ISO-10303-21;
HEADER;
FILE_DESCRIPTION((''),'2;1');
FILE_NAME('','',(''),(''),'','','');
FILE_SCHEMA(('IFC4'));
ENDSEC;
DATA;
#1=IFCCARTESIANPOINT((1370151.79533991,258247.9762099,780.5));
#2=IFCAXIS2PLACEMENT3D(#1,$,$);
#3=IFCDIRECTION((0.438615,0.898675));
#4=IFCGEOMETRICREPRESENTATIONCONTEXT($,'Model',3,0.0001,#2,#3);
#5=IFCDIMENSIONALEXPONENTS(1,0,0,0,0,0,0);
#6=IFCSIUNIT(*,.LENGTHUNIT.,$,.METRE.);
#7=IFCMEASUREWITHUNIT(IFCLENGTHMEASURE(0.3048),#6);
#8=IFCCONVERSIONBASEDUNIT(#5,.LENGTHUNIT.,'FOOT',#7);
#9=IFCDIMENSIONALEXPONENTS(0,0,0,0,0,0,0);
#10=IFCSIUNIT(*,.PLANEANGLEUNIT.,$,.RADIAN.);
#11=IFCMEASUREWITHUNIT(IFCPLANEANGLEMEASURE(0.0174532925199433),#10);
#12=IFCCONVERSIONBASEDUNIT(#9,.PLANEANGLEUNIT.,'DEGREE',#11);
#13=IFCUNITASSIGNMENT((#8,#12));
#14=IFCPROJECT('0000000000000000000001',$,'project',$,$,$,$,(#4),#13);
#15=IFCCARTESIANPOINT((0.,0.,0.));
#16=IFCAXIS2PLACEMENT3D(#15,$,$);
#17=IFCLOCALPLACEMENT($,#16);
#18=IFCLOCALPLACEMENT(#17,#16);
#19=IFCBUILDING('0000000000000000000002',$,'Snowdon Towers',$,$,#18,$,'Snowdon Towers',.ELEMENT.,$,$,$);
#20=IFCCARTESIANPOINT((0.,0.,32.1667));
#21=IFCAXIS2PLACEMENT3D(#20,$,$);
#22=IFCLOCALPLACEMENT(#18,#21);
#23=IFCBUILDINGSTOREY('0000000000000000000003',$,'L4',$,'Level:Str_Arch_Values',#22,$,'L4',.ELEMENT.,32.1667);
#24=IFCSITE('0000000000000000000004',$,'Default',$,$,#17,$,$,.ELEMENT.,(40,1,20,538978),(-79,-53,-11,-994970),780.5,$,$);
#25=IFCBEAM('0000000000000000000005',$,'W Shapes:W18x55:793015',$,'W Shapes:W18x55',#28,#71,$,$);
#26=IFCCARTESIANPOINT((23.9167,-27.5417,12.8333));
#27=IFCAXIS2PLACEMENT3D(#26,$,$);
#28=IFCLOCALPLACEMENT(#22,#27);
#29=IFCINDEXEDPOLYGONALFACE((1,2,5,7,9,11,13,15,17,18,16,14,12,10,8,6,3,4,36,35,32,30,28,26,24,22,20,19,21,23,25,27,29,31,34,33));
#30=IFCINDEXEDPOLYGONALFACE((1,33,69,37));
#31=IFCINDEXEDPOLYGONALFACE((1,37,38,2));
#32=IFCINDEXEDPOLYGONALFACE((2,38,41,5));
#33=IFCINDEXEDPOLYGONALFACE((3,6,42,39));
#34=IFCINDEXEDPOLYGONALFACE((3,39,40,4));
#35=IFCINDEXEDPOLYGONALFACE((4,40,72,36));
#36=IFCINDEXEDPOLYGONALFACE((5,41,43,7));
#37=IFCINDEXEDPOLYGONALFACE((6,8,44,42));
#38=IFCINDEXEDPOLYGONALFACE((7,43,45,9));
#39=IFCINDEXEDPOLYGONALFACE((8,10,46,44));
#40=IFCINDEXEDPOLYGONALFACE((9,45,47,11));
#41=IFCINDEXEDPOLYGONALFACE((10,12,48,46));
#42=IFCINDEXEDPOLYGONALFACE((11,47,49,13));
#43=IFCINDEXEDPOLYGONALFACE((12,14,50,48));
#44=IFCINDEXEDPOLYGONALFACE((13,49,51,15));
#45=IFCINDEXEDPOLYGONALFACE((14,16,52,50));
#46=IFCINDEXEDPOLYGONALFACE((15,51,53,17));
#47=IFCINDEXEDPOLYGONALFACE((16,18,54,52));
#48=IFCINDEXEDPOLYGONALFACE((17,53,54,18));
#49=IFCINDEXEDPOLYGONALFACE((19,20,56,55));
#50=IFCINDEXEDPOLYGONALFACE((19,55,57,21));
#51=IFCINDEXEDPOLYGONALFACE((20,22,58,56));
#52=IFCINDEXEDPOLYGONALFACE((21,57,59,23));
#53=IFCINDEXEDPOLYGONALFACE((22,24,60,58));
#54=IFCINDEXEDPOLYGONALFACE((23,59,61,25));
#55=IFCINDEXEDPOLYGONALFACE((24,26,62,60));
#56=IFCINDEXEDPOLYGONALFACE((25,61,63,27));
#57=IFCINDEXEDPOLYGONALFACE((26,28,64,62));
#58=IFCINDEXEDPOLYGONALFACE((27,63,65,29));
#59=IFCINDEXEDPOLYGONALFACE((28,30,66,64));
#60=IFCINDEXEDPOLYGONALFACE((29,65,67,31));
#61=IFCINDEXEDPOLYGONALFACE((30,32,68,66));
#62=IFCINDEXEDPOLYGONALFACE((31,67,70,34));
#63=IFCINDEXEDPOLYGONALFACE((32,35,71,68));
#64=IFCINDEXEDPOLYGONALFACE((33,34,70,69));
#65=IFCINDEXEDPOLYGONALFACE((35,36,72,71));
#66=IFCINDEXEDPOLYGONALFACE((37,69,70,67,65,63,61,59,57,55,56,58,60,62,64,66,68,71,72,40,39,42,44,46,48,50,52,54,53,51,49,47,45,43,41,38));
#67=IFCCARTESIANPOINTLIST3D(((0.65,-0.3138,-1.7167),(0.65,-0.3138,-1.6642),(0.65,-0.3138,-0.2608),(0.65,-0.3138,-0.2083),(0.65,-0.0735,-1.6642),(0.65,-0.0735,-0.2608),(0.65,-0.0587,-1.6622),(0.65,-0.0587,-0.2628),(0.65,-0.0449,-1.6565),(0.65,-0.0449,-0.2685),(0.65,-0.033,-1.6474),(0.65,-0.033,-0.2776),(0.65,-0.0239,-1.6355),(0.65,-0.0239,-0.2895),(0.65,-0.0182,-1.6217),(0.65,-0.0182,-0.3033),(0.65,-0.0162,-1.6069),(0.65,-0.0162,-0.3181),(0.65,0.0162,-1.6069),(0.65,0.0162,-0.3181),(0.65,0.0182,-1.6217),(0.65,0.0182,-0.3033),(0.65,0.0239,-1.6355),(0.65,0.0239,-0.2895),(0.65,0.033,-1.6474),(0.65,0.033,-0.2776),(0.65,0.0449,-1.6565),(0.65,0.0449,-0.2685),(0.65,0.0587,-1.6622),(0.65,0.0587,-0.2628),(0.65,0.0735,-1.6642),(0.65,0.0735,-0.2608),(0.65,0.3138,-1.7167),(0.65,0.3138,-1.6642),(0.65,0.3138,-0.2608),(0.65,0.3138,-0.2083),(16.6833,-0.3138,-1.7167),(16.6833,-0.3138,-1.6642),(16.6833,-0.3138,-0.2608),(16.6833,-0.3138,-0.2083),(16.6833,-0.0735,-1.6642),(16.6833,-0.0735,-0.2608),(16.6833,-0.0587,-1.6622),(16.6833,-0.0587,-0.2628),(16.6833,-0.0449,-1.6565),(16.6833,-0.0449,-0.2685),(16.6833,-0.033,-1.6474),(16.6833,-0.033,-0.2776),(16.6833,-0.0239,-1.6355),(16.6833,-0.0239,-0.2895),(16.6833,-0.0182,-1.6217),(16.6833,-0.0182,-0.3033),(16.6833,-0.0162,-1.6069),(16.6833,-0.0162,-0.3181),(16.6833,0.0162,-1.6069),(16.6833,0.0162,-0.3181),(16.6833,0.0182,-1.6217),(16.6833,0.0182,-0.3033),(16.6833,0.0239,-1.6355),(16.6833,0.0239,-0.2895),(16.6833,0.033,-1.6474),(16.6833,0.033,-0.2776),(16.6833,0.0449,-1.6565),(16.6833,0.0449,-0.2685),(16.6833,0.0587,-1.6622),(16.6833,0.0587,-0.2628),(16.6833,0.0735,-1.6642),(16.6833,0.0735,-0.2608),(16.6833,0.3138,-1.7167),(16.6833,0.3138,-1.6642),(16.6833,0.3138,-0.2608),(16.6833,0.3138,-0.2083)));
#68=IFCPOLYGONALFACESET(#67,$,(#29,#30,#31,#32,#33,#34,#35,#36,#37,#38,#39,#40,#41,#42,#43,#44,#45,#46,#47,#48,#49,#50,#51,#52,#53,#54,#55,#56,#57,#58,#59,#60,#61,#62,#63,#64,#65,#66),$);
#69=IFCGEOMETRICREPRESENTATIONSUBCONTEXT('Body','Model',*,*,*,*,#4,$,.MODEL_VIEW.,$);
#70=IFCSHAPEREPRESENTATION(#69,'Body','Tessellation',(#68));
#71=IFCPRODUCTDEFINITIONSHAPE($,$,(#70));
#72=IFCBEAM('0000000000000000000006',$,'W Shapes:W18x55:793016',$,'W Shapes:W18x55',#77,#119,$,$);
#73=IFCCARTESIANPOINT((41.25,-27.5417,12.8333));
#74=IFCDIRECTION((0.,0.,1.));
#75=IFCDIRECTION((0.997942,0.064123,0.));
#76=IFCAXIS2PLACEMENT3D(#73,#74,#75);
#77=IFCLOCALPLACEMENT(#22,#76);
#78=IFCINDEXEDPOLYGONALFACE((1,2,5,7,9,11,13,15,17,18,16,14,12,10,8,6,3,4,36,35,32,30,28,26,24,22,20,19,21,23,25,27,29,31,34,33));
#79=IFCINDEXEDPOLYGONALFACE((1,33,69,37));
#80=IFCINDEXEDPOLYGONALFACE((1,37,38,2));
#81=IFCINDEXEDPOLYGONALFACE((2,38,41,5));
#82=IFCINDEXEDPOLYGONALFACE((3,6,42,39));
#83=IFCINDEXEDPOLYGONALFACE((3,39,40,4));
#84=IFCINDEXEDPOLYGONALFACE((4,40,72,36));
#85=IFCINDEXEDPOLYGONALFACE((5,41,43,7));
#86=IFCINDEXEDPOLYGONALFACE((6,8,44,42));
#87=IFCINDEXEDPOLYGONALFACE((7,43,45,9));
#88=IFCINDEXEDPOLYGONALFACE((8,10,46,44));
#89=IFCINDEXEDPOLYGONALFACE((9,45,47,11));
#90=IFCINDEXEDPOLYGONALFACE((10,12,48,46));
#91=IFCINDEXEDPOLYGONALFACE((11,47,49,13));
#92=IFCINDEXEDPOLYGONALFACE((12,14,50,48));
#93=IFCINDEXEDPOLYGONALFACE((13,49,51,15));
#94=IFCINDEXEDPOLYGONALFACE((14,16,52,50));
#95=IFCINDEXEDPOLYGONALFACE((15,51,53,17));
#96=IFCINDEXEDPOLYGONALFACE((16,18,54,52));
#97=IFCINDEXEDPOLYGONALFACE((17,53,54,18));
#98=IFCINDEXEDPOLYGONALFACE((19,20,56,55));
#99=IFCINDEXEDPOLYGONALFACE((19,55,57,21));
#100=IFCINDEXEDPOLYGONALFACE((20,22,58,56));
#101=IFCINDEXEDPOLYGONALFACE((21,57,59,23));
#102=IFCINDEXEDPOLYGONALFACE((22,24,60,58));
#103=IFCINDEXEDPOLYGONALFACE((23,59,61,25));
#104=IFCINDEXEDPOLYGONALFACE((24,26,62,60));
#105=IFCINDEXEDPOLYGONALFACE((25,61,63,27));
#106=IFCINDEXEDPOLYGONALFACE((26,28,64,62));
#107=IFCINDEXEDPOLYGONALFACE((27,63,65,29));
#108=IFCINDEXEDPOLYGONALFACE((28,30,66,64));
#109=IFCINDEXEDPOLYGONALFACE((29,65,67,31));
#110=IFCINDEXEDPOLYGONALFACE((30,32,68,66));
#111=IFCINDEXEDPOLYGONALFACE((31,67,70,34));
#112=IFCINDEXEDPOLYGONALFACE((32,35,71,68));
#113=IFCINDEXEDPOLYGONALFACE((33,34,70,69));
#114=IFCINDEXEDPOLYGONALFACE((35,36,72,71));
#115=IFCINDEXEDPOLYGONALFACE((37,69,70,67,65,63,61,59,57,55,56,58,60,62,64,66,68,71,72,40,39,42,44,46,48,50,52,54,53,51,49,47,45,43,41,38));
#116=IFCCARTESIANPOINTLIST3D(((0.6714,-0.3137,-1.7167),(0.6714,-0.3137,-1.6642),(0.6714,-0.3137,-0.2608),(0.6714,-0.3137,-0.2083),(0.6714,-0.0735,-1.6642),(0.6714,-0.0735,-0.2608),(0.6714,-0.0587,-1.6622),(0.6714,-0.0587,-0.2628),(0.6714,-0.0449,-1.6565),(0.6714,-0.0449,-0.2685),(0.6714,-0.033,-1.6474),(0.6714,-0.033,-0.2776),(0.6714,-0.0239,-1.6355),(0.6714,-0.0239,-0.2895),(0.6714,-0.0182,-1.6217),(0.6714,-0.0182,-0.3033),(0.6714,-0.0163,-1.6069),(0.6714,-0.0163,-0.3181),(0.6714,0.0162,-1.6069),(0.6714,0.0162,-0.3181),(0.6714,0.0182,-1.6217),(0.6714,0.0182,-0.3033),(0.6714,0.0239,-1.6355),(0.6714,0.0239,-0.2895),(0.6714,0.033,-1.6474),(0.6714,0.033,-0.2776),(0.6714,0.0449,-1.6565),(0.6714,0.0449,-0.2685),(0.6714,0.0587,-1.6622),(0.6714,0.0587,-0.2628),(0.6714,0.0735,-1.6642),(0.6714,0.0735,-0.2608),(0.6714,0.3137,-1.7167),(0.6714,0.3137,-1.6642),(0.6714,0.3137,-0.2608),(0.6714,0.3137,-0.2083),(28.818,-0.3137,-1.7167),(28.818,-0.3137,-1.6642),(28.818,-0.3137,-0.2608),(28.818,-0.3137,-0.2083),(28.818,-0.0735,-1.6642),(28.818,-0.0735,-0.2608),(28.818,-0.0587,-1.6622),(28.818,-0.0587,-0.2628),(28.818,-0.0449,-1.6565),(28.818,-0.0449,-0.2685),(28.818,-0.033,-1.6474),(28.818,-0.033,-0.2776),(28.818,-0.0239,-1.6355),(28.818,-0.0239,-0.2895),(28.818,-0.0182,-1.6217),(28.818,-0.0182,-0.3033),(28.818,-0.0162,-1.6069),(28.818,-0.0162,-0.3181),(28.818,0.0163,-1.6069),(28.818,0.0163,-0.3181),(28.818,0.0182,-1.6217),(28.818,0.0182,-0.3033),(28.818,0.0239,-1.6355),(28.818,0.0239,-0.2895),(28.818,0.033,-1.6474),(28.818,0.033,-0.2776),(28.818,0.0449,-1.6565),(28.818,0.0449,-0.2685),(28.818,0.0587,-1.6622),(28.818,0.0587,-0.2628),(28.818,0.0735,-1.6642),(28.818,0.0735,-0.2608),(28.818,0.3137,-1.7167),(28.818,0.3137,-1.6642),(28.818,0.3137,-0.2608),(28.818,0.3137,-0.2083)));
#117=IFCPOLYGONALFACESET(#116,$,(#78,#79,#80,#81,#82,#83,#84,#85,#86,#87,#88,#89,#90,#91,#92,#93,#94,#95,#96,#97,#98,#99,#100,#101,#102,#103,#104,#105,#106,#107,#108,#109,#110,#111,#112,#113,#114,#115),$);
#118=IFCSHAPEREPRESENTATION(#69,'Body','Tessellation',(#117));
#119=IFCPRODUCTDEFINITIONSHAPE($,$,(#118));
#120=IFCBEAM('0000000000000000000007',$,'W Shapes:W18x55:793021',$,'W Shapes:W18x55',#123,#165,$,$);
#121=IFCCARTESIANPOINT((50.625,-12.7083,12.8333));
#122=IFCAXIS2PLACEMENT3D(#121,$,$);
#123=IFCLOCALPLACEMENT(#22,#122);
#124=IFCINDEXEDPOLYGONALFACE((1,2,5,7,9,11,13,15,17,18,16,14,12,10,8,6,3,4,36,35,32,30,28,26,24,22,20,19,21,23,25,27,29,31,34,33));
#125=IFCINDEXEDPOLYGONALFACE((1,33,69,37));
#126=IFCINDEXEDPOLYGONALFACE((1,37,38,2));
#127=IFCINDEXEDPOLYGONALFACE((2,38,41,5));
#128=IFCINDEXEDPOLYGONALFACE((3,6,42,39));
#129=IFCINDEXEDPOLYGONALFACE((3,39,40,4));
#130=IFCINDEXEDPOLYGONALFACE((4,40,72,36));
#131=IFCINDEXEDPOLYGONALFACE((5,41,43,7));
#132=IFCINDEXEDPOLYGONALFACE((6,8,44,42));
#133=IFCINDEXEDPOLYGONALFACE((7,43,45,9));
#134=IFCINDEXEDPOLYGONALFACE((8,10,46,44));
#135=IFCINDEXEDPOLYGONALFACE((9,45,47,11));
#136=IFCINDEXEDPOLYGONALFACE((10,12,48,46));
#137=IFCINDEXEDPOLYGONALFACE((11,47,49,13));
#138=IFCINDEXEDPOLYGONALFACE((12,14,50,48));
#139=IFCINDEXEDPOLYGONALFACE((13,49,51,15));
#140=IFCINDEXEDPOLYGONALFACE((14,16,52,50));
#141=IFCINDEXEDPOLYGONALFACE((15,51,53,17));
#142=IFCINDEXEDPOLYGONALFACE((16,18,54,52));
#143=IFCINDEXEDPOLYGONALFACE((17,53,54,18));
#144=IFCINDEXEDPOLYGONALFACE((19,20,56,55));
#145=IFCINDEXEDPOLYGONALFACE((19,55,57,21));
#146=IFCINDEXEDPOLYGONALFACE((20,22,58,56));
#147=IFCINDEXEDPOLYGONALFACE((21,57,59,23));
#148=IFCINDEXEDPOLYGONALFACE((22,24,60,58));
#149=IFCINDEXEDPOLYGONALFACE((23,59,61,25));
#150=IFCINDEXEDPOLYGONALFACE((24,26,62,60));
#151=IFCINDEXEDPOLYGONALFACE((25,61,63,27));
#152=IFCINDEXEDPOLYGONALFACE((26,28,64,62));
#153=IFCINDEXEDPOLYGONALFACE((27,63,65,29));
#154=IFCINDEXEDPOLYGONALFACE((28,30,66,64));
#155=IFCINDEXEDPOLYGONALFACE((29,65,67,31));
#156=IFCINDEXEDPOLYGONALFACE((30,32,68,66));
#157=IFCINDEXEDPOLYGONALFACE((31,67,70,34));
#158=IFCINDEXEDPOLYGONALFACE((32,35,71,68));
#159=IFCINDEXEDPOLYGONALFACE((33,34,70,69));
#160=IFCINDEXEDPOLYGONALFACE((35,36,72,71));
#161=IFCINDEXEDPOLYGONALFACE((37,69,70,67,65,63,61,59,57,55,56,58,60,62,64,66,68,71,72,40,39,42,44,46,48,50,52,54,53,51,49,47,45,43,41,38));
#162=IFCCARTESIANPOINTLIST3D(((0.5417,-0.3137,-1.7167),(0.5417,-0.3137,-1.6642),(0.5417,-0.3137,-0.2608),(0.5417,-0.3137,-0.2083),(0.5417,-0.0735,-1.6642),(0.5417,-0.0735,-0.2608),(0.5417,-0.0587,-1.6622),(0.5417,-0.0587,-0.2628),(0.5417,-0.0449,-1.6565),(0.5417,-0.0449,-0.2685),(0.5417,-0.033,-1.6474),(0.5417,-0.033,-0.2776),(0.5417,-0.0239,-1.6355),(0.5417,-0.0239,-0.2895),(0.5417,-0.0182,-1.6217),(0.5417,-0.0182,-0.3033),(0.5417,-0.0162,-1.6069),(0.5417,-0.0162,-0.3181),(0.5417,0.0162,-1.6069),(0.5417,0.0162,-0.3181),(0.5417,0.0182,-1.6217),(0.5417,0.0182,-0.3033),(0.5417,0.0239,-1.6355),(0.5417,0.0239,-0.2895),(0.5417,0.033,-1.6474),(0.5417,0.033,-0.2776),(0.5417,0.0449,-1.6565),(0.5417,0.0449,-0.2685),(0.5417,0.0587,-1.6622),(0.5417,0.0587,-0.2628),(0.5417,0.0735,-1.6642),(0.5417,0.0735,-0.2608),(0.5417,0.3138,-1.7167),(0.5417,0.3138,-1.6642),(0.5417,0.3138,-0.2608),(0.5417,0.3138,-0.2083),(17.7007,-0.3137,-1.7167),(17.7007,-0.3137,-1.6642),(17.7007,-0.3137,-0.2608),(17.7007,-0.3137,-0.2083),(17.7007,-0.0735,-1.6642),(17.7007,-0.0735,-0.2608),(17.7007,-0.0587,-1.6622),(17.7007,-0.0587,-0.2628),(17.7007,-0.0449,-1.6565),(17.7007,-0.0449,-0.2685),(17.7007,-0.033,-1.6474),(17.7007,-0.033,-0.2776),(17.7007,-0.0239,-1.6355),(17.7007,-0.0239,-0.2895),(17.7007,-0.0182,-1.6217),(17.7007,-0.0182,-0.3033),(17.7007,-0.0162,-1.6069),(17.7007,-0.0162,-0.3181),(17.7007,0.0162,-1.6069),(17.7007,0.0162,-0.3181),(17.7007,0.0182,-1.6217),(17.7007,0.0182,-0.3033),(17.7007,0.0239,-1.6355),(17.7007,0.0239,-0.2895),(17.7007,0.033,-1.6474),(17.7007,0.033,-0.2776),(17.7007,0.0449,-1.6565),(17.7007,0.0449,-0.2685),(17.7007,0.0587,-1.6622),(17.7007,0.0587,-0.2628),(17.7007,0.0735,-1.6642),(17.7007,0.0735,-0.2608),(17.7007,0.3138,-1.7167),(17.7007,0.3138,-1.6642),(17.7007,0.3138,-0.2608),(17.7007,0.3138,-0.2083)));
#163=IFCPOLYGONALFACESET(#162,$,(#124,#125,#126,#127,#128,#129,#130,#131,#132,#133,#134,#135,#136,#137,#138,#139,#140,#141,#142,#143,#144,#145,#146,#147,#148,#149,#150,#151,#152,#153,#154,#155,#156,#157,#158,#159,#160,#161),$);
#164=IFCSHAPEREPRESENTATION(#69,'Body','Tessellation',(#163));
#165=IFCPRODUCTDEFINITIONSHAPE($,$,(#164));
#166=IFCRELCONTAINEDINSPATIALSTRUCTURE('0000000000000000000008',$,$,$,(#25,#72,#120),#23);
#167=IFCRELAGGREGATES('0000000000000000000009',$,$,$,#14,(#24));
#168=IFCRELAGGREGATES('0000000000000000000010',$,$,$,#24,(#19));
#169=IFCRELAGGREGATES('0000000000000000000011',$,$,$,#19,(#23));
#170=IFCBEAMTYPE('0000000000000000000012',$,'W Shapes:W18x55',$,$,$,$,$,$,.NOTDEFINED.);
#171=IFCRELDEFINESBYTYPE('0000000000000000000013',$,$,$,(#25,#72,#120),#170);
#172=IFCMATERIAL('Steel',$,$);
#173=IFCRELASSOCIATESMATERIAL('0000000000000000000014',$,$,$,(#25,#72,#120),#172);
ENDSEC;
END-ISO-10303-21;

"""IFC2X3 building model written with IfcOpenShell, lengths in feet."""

from ifc_helpers import new_model, entity, si_unit, converted_unit, direction, frame, frame_2d, origin, place, context, subcontext, project, spatial, i_section, extrude, material, type_object, element, save


model = new_model("IFC2X3")

# Units and contexts
model_context = context("Model", 3, precision=0.0001, world=frame((1370151.79533991, 258247.9762099, 780.5)), true_north=direction((0.438615, 0.898675)))
body_context = subcontext(model_context, "Body", "Model", "MODEL_VIEW")
ifc_project = project(units=[converted_unit("LENGTHUNIT", "FOOT", entity("IfcLengthMeasure", 0.3048), si_unit("LENGTHUNIT", "METRE"), dimensions=[1, 0, 0, 0, 0, 0, 0]), converted_unit("PLANEANGLEUNIT", "DEGREE", entity("IfcPlaneAngleMeasure", 0.0174532925199433), si_unit("PLANEANGLEUNIT", "RADIAN"), dimensions=[0, 0, 0, 0, 0, 0, 0])], contexts=[model_context])

# Site, building, storey
site_placement = place(None, origin())
site = spatial("IfcSite", under=ifc_project, at=site_placement, Name="Default", CompositionType="ELEMENT", RefLatitude=(40, 1, 20, 538978), RefLongitude=(-79, -53, -11, -994970), RefElevation=780.5)
building_placement = place(site_placement, origin())
building = spatial("IfcBuilding", under=site, at=building_placement, Name="Snowdon Towers", LongName="Snowdon Towers", CompositionType="ELEMENT")
storey_placement = place(building_placement, frame((0.0, 0.0, 32.1667)))
storey = spatial("IfcBuildingStorey", under=building, at=storey_placement, Name="L4", ObjectType="Level:Str_Arch_Values", LongName="L4", CompositionType="ELEMENT", Elevation=32.1667)

# Beams
ifc_material = material(Name="Steel")
beam_type_1 = type_object("IfcBeamType", Name="W Shapes:W18x55", PredefinedType="NOTDEFINED")
beam_1_placement = place(storey_placement, frame((23.9167, -27.5417, 12.8333)))
element("IfcBeam", 1, at=beam_1_placement, inside=storey, type_object=beam_type_1, material=ifc_material, Name="W Shapes:W18x55:793015", ObjectType="W Shapes:W18x55", context=body_context, shape_type="SweptSolid", body=[
    extrude(i_section(OverallWidth=0.6275, OverallDepth=1.5083, WebThickness=0.0325, FlangeThickness=0.0525, FilletRadius=0.0573, at=frame_2d((0.0, 0.0), x_axis=(0.0, 1.0))), frame((0.65, 0.0, -0.9625), z_axis=(1.0, 0.0, 0.0), x_axis=(0.0, 0.0, -1.0)), (0.0, 0.0, 1.0), 16.0333),
])
beam_2_placement = place(storey_placement, frame((41.25, -27.5417, 12.8333), z_axis=(0.0, 0.0, 1.0), x_axis=(0.997942, 0.064123, 0.0)))
element("IfcBeam", 2, at=beam_2_placement, inside=storey, type_object=beam_type_1, material=ifc_material, Name="W Shapes:W18x55:793016", ObjectType="W Shapes:W18x55", context=body_context, shape_type="SweptSolid", body=[
    extrude(i_section(OverallWidth=0.6275, OverallDepth=1.5083, WebThickness=0.0325, FlangeThickness=0.0525, FilletRadius=0.0573, at=frame_2d((0.0, 0.0), x_axis=(0.0, 1.0))), frame((0.6714, 0.0, -0.9625), z_axis=(1.0, 0.0, 0.0), x_axis=(0.0, 0.0, -1.0)), (0.0, 0.0, 1.0), 28.1466),
])
beam_3_placement = place(storey_placement, frame((50.625, -12.7083, 12.8333)))
element("IfcBeam", 3, at=beam_3_placement, inside=storey, type_object=beam_type_1, material=ifc_material, Name="W Shapes:W18x55:793021", ObjectType="W Shapes:W18x55", context=body_context, shape_type="SweptSolid", body=[
    extrude(i_section(OverallWidth=0.6275, OverallDepth=1.5083, WebThickness=0.0325, FlangeThickness=0.0525, FilletRadius=0.0573, at=frame_2d((0.0, 0.0), x_axis=(0.0, 1.0))), frame((0.5417, 0.0, -0.9625), z_axis=(1.0, 0.0, 0.0), x_axis=(0.0, 0.0, -1.0)), (0.0, 0.0, 1.0), 17.159),
])

save(model, "model.ifc")
